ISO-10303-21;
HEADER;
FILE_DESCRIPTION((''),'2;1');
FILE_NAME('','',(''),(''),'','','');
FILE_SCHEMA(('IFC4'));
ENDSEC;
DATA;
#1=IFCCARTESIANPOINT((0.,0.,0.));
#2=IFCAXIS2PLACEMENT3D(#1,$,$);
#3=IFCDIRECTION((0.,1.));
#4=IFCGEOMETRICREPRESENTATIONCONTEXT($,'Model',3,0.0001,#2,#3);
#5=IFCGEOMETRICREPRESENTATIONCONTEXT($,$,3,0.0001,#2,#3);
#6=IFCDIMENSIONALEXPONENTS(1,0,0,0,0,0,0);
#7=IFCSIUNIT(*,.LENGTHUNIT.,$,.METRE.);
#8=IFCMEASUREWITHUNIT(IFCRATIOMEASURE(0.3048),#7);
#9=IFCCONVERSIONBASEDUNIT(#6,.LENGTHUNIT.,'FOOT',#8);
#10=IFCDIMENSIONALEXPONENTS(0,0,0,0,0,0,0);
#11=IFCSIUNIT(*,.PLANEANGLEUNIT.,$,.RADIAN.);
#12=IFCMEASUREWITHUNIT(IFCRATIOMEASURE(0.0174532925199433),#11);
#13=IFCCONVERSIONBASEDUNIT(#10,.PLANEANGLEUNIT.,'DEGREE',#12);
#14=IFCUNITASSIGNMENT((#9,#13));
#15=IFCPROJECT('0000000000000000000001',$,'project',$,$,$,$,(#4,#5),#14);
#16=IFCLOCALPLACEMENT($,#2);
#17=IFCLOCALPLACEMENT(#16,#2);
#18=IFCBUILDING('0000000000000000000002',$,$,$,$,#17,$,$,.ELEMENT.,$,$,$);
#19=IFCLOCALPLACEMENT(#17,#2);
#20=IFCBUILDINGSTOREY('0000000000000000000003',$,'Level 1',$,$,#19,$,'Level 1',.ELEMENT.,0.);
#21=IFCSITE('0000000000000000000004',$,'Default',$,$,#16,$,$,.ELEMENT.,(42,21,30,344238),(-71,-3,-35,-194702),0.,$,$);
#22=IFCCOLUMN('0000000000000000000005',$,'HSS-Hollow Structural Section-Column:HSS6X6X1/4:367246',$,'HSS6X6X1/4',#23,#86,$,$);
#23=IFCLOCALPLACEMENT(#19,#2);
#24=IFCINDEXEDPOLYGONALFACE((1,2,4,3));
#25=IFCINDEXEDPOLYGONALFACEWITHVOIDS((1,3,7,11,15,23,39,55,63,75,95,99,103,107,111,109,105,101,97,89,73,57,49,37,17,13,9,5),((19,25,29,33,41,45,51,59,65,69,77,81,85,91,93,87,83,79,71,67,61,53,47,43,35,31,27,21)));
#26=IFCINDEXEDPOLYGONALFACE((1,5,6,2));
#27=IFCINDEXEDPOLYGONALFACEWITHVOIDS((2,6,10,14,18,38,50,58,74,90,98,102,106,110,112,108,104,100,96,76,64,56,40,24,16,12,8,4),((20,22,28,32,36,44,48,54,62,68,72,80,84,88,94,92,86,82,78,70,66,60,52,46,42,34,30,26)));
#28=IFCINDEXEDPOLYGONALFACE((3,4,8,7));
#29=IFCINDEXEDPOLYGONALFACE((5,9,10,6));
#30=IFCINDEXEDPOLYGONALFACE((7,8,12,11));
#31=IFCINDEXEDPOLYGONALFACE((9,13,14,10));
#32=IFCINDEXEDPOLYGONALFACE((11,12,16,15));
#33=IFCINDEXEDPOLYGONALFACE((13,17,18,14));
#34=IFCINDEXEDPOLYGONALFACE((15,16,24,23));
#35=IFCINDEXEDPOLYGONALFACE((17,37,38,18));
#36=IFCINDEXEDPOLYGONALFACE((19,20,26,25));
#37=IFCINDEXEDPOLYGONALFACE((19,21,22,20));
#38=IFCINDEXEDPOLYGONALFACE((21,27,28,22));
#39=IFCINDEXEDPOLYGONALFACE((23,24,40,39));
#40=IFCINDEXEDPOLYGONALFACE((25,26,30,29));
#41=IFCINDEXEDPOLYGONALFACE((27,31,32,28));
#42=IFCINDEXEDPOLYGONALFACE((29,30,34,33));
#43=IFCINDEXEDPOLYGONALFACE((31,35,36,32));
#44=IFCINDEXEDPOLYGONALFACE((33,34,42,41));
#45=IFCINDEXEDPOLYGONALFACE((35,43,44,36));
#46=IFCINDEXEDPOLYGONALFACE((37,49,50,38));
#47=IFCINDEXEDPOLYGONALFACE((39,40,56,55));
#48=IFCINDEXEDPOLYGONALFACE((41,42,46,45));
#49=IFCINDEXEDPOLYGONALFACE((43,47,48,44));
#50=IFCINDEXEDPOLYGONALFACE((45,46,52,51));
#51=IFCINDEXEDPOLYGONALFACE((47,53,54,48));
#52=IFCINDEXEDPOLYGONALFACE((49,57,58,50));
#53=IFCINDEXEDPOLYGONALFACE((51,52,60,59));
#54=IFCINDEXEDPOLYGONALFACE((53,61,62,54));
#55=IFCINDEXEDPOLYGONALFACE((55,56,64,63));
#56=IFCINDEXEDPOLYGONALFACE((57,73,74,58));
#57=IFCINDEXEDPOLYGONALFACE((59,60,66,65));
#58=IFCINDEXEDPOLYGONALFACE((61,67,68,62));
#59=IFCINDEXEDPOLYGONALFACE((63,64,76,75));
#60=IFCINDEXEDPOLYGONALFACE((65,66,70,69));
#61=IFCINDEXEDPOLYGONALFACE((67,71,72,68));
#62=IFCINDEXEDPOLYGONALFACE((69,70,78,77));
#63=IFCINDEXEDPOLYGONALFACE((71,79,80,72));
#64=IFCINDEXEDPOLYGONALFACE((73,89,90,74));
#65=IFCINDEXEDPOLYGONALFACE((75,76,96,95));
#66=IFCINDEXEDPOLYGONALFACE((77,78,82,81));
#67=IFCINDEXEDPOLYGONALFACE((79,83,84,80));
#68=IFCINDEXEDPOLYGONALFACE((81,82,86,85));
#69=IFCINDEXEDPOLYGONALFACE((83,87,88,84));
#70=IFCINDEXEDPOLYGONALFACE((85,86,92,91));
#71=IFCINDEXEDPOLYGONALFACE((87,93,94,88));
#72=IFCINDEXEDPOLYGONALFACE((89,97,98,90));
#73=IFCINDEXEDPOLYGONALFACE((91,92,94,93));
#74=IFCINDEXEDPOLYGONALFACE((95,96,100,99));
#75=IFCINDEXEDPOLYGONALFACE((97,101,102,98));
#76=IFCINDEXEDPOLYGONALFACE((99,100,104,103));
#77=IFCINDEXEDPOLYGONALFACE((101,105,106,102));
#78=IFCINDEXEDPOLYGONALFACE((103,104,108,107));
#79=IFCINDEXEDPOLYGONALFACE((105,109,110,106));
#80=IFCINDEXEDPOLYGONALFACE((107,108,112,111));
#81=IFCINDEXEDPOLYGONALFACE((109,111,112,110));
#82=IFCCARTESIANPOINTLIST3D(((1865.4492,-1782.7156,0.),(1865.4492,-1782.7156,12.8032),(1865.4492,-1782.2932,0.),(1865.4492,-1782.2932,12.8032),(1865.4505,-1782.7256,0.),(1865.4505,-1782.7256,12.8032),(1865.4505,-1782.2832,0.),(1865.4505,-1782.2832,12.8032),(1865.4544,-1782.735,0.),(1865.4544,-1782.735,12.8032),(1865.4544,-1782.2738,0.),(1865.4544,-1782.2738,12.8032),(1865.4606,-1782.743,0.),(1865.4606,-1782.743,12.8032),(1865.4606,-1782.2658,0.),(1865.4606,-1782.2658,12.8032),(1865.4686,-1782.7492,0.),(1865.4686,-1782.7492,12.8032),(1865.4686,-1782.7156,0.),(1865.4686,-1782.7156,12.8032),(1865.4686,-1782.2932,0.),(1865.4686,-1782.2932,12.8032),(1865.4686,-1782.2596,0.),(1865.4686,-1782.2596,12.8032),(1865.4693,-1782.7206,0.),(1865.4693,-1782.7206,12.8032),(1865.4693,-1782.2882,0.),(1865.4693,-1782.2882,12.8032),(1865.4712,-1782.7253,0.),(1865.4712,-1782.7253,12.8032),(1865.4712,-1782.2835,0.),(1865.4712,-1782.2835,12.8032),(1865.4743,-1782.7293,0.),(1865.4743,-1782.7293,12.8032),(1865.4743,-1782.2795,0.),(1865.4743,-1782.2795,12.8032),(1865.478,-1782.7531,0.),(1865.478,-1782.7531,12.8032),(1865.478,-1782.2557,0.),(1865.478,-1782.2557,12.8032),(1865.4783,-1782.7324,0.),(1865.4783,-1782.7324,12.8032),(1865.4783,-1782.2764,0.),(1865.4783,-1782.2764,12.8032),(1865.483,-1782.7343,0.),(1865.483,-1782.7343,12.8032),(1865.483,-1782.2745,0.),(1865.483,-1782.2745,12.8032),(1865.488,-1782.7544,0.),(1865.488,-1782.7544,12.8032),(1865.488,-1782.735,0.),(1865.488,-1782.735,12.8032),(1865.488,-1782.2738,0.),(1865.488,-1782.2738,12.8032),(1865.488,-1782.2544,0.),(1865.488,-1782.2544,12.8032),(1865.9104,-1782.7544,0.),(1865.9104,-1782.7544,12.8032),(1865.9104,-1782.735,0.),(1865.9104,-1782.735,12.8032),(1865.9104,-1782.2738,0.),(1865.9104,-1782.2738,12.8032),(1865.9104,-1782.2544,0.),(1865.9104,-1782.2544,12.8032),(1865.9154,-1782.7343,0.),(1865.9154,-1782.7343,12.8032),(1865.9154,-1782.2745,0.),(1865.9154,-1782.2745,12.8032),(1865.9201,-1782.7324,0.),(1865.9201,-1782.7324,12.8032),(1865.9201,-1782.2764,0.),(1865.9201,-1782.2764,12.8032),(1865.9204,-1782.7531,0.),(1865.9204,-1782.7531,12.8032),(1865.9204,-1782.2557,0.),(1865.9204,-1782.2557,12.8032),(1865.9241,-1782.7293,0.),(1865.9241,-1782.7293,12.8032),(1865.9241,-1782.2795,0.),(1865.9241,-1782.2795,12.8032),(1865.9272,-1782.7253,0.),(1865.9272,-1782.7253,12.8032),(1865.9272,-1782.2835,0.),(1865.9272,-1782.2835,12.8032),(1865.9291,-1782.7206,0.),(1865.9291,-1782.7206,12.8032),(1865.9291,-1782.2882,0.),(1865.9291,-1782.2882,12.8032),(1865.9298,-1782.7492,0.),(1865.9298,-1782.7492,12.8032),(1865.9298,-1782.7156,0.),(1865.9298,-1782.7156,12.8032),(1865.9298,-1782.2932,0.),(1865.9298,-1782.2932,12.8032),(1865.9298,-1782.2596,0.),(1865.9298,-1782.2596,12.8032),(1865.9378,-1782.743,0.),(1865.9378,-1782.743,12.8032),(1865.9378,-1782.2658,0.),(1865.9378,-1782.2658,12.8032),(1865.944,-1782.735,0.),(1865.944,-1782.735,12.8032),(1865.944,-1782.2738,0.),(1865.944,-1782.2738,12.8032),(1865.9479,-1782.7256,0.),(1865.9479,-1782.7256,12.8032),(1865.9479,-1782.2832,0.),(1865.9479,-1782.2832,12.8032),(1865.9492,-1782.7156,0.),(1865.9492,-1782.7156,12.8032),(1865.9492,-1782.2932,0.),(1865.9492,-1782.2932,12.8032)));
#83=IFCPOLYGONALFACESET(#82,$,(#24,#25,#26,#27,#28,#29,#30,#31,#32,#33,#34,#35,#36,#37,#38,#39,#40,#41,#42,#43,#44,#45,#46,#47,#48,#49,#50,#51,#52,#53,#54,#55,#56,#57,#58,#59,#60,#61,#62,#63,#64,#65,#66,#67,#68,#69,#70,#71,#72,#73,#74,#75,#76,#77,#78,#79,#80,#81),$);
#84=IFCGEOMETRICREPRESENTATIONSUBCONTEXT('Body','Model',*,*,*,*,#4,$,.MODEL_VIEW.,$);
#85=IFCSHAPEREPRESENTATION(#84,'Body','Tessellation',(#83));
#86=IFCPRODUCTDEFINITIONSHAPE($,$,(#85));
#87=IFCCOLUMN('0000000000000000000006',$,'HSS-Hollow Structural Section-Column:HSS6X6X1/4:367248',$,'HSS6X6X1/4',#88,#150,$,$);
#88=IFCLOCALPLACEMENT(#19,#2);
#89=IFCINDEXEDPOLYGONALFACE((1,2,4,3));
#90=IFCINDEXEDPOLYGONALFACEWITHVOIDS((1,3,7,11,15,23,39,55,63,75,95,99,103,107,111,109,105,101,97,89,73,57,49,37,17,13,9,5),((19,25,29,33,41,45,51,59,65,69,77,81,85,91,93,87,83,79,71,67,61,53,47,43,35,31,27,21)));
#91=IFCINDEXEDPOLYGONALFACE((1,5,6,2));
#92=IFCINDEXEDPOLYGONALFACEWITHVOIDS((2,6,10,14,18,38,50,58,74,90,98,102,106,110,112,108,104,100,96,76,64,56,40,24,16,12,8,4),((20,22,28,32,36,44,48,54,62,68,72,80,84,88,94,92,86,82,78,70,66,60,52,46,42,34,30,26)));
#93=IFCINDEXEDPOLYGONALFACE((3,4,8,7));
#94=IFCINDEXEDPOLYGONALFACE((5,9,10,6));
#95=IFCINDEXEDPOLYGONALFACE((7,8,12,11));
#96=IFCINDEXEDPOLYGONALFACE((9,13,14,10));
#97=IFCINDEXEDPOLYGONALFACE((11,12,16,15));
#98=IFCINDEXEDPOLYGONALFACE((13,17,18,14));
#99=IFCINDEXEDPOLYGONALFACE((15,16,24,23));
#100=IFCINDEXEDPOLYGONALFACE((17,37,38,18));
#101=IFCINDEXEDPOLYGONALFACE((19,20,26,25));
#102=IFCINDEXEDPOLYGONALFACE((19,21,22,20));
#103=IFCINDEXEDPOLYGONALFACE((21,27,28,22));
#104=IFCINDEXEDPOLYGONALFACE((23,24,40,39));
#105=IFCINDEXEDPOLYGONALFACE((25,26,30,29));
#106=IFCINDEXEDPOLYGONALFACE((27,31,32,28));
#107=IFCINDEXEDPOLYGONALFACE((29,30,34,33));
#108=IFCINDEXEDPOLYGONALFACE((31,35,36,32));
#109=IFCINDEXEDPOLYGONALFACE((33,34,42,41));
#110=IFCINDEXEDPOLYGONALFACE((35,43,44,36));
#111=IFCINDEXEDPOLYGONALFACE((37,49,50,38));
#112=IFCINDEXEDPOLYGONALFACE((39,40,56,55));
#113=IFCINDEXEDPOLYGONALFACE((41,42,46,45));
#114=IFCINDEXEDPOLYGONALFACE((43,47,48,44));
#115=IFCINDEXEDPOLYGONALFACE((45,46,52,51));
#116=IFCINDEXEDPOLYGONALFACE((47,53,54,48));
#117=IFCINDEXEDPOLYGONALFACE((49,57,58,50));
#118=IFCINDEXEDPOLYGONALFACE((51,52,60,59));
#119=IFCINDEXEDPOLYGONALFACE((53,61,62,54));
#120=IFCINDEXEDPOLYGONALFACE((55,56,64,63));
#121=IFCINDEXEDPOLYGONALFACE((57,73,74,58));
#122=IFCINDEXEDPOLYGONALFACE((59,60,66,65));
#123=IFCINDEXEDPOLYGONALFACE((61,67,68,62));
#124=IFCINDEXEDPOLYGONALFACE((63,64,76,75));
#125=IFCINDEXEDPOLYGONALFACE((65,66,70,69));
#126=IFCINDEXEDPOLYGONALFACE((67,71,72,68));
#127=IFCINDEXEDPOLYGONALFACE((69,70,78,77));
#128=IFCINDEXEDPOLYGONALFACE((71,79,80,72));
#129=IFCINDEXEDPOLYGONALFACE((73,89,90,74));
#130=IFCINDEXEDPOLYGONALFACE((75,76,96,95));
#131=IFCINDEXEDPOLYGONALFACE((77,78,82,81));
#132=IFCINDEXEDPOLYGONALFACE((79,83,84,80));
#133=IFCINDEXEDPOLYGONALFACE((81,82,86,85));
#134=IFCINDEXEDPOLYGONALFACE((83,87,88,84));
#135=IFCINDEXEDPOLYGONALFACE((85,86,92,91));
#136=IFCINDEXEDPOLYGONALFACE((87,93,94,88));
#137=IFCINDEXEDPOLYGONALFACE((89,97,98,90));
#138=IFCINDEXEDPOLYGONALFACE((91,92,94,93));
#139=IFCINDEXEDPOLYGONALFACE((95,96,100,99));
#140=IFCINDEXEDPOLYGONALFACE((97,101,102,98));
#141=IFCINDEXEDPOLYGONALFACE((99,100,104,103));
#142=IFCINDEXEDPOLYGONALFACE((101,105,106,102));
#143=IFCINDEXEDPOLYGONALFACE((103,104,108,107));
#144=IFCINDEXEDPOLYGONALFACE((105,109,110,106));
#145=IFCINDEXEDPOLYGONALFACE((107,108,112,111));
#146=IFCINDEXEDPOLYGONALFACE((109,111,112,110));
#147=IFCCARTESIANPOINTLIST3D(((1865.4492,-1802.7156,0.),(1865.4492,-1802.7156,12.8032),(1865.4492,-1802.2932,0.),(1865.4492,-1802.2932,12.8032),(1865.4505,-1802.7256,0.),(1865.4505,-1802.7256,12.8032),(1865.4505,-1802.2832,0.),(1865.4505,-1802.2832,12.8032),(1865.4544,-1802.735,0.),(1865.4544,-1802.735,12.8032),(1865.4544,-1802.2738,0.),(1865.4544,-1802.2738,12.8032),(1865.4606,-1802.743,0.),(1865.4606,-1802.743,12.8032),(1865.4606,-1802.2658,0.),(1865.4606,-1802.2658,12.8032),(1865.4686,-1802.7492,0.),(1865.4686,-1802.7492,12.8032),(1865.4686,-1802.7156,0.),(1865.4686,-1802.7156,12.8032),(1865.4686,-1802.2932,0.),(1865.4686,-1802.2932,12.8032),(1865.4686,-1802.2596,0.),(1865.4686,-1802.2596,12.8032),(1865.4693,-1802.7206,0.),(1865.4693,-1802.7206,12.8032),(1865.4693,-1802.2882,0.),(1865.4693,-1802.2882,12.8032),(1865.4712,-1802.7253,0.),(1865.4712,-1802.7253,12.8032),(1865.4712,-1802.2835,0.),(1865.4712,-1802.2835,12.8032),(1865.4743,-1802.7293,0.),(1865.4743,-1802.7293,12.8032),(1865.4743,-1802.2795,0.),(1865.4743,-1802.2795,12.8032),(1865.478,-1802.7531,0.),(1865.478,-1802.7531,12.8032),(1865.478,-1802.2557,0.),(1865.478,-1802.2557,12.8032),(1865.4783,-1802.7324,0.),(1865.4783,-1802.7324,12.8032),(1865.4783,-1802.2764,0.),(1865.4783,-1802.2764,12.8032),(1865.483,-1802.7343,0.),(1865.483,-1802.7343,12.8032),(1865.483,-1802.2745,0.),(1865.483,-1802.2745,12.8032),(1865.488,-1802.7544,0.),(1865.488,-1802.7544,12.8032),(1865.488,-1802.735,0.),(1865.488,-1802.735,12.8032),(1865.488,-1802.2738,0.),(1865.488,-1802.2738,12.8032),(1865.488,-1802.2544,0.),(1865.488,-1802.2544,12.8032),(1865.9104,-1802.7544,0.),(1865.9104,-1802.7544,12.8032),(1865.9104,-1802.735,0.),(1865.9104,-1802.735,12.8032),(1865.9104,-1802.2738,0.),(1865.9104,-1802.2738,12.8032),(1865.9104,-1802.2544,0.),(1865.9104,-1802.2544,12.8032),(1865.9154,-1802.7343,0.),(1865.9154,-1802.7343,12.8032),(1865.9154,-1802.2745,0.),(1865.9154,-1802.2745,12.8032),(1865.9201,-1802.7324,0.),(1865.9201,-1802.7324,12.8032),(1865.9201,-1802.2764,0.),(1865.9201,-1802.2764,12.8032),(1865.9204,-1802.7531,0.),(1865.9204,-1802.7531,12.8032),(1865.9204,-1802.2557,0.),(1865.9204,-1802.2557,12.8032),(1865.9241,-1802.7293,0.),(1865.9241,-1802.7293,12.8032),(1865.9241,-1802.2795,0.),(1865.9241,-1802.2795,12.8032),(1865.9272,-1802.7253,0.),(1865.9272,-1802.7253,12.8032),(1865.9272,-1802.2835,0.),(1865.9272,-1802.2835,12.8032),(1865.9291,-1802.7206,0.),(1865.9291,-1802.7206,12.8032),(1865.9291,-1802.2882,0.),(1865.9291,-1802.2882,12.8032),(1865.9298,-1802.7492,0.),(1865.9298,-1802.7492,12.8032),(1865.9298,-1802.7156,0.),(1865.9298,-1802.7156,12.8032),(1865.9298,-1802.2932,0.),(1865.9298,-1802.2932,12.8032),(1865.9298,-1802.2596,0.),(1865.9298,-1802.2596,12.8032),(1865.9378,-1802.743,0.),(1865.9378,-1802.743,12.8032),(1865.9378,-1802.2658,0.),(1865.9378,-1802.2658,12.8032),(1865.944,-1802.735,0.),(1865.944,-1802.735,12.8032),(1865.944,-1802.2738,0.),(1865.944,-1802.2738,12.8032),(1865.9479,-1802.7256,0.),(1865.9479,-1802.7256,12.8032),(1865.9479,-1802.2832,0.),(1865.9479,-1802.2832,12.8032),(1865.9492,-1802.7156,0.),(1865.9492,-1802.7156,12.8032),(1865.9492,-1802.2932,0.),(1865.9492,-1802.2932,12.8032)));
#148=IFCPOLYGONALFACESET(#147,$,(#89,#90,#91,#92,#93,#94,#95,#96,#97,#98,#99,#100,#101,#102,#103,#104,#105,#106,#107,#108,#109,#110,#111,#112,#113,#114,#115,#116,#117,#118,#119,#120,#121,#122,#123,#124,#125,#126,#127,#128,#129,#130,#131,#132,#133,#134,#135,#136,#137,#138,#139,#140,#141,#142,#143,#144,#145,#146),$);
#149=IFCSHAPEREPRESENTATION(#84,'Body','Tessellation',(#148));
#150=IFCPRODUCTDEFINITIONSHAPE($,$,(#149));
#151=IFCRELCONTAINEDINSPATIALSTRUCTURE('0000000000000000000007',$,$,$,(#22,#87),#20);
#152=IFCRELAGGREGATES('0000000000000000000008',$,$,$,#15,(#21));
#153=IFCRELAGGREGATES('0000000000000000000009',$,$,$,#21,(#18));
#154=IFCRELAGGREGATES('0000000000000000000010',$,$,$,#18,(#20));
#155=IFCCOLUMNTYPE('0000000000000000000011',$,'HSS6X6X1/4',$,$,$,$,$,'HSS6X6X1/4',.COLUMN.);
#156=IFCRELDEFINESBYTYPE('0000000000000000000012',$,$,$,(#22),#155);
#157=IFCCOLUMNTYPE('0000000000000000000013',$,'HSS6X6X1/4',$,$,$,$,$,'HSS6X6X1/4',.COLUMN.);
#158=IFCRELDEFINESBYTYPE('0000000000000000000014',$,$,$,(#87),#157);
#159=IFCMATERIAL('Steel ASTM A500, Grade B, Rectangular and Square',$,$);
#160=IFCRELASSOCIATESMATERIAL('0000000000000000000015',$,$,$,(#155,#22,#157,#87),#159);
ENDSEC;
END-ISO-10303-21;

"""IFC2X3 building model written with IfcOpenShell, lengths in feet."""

from ifc_helpers import new_model, entity, si_unit, converted_unit, direction, frame, frame_2d, origin, place, context, subcontext, project, spatial, polyline, circle_curve, parameter, trimmed, segment, composite_curve, outline, extrude, source, transform, mapped, material, type_object, type_shapes, element, save


model = new_model("IFC2X3")

# Units and contexts
model_context = context("Model", 3, precision=0.0001, world=origin(), true_north=direction((0.0, 1.0)))
context_of_model = context(None, 3, precision=0.0001, world=origin(), true_north=direction((0.0, 1.0)))
body_context = subcontext(model_context, "Body", "Model", "MODEL_VIEW")
ifc_project = project(units=[converted_unit("LENGTHUNIT", "FOOT", entity("IfcRatioMeasure", 0.3048), si_unit("LENGTHUNIT", "METRE"), dimensions=[1, 0, 0, 0, 0, 0, 0]), converted_unit("PLANEANGLEUNIT", "DEGREE", entity("IfcRatioMeasure", 0.0174532925199433), si_unit("PLANEANGLEUNIT", "RADIAN"), dimensions=[0, 0, 0, 0, 0, 0, 0])], contexts=[model_context, context_of_model])

# Site, building, storey
site_placement = place(None, origin())
site = spatial("IfcSite", under=ifc_project, at=site_placement, Name="Default", CompositionType="ELEMENT", RefLatitude=(42, 21, 30, 344238), RefLongitude=(-71, -3, -35, -194702), RefElevation=0.0)
building_placement = place(site_placement, origin())
building = spatial("IfcBuilding", under=site, at=building_placement, CompositionType="ELEMENT")
storey_placement = place(building_placement, origin())
storey = spatial("IfcBuildingStorey", under=building, at=storey_placement, Name="Level 1", LongName="Level 1", CompositionType="ELEMENT", Elevation=0.0)

# Columns
ifc_material_1 = material(Name="Steel ASTM A500, Grade B, Rectangular and Square")
column_type_1 = type_object("IfcColumnType", Name="HSS6X6X1/4", ElementType="HSS6X6X1/4", PredefinedType="COLUMN", material=ifc_material_1)
shared_shape_1 = source(origin(), body_context, "Body", "SweptSolid", [
    extrude(outline(composite_curve([segment(polyline([(-0.2112, -0.25), (0.2112, -0.25)]), True, "CONTINUOUS"), segment(trimmed(circle_curve(frame_2d((0.2112, -0.2112), x_axis=(-1.0, 0.0)), 0.0388), [parameter(90.0)], [parameter(180.0)], True, "PARAMETER"), True, "CONTINUOUS"), segment(polyline([(0.25, -0.2112), (0.25, 0.2112)]), True, "CONTINUOUS"), segment(trimmed(circle_curve(frame_2d((0.2112, 0.2112), x_axis=(-1.0, 0.0)), 0.0388), [parameter(180.0)], [parameter(270.0)], True, "PARAMETER"), True, "CONTINUOUS"), segment(polyline([(0.2112, 0.25), (-0.2112, 0.25)]), True, "CONTINUOUS"), segment(trimmed(circle_curve(frame_2d((-0.2112, 0.2112), x_axis=(-1.0, 0.0)), 0.0388), [parameter(270.0)], [parameter(360.0)], True, "PARAMETER"), True, "CONTINUOUS"), segment(polyline([(-0.25, 0.2112), (-0.25, -0.2112)]), True, "CONTINUOUS"), segment(trimmed(circle_curve(frame_2d((-0.2112, -0.2112), x_axis=(-1.0, 0.0)), 0.0388), [parameter(360.0)], [parameter(90.0)], True, "PARAMETER"), True, "CONTINUOUS")], self_intersect=False), holes=[composite_curve([segment(trimmed(circle_curve(frame_2d((-0.2112, -0.2112), x_axis=(-1.0, 0.0)), 0.0194), [parameter(0.0)], [parameter(90.0)], True, "PARAMETER"), False, "CONTINUOUS"), segment(polyline([(-0.2306, -0.2112), (-0.2306, 0.2112)]), True, "CONTINUOUS"), segment(trimmed(circle_curve(frame_2d((-0.2112, 0.2112), x_axis=(-1.0, 0.0)), 0.0194), [parameter(270.0)], [parameter(360.0)], True, "PARAMETER"), False, "CONTINUOUS"), segment(polyline([(-0.2112, 0.2306), (0.2112, 0.2306)]), True, "CONTINUOUS"), segment(trimmed(circle_curve(frame_2d((0.2112, 0.2112), x_axis=(-1.0, 0.0)), 0.0194), [parameter(180.0)], [parameter(270.0)], True, "PARAMETER"), False, "CONTINUOUS"), segment(polyline([(0.2306, 0.2112), (0.2306, -0.2112)]), True, "CONTINUOUS"), segment(trimmed(circle_curve(frame_2d((0.2112, -0.2112), x_axis=(-1.0, 0.0)), 0.0194), [parameter(90.0)], [parameter(180.0)], True, "PARAMETER"), False, "CONTINUOUS"), segment(polyline([(0.2112, -0.2306), (-0.2112, -0.2306)]), True, "CONTINUOUS")], self_intersect=False)]), frame((1865.6992, -1782.5044, 0.0)), (0.0, 0.0, 1.0), 12.8032),
])
type_shapes(column_type_1, [shared_shape_1])
column_1_placement = place(storey_placement, origin())
element("IfcColumn", 1, at=column_1_placement, inside=storey, type_object=column_type_1, material=ifc_material_1, Name="HSS-Hollow Structural Section-Column:HSS6X6X1/4:367246", ObjectType="HSS6X6X1/4", context=body_context, shape_type="MappedRepresentation", body=[
    mapped(shared_shape_1, transform((0.0, 0.0, 0.0), scale=1.0)),
])
column_type_2 = type_object("IfcColumnType", Name="HSS6X6X1/4", ElementType="HSS6X6X1/4", PredefinedType="COLUMN", material=ifc_material_1)
shared_shape_2 = source(origin(), body_context, "Body", "SweptSolid", [
    extrude(outline(composite_curve([segment(polyline([(-0.2112, -0.25), (0.2112, -0.25)]), True, "CONTINUOUS"), segment(trimmed(circle_curve(frame_2d((0.2112, -0.2112), x_axis=(-1.0, 0.0)), 0.0388), [parameter(90.0)], [parameter(180.0)], True, "PARAMETER"), True, "CONTINUOUS"), segment(polyline([(0.25, -0.2112), (0.25, 0.2112)]), True, "CONTINUOUS"), segment(trimmed(circle_curve(frame_2d((0.2112, 0.2112), x_axis=(-1.0, 0.0)), 0.0388), [parameter(180.0)], [parameter(270.0)], True, "PARAMETER"), True, "CONTINUOUS"), segment(polyline([(0.2112, 0.25), (-0.2112, 0.25)]), True, "CONTINUOUS"), segment(trimmed(circle_curve(frame_2d((-0.2112, 0.2112), x_axis=(-1.0, 0.0)), 0.0388), [parameter(270.0)], [parameter(360.0)], True, "PARAMETER"), True, "CONTINUOUS"), segment(polyline([(-0.25, 0.2112), (-0.25, -0.2112)]), True, "CONTINUOUS"), segment(trimmed(circle_curve(frame_2d((-0.2112, -0.2112), x_axis=(-1.0, 0.0)), 0.0388), [parameter(360.0)], [parameter(90.0)], True, "PARAMETER"), True, "CONTINUOUS")], self_intersect=False), holes=[composite_curve([segment(trimmed(circle_curve(frame_2d((-0.2112, -0.2112), x_axis=(-1.0, 0.0)), 0.0194), [parameter(0.0)], [parameter(90.0)], True, "PARAMETER"), False, "CONTINUOUS"), segment(polyline([(-0.2306, -0.2112), (-0.2306, 0.2112)]), True, "CONTINUOUS"), segment(trimmed(circle_curve(frame_2d((-0.2112, 0.2112), x_axis=(-1.0, 0.0)), 0.0194), [parameter(270.0)], [parameter(360.0)], True, "PARAMETER"), False, "CONTINUOUS"), segment(polyline([(-0.2112, 0.2306), (0.2112, 0.2306)]), True, "CONTINUOUS"), segment(trimmed(circle_curve(frame_2d((0.2112, 0.2112), x_axis=(-1.0, 0.0)), 0.0194), [parameter(180.0)], [parameter(270.0)], True, "PARAMETER"), False, "CONTINUOUS"), segment(polyline([(0.2306, 0.2112), (0.2306, -0.2112)]), True, "CONTINUOUS"), segment(trimmed(circle_curve(frame_2d((0.2112, -0.2112), x_axis=(-1.0, 0.0)), 0.0194), [parameter(90.0)], [parameter(180.0)], True, "PARAMETER"), False, "CONTINUOUS"), segment(polyline([(0.2112, -0.2306), (-0.2112, -0.2306)]), True, "CONTINUOUS")], self_intersect=False)]), frame((1865.6992, -1802.5044, 0.0)), (0.0, 0.0, 1.0), 12.8032),
])
type_shapes(column_type_2, [shared_shape_2])
column_2_placement = place(storey_placement, origin())
element("IfcColumn", 2, at=column_2_placement, inside=storey, type_object=column_type_2, material=ifc_material_1, Name="HSS-Hollow Structural Section-Column:HSS6X6X1/4:367248", ObjectType="HSS6X6X1/4", context=body_context, shape_type="MappedRepresentation", body=[
    mapped(shared_shape_2, transform((0.0, 0.0, 0.0), scale=1.0)),
])

save(model, "model.ifc")
